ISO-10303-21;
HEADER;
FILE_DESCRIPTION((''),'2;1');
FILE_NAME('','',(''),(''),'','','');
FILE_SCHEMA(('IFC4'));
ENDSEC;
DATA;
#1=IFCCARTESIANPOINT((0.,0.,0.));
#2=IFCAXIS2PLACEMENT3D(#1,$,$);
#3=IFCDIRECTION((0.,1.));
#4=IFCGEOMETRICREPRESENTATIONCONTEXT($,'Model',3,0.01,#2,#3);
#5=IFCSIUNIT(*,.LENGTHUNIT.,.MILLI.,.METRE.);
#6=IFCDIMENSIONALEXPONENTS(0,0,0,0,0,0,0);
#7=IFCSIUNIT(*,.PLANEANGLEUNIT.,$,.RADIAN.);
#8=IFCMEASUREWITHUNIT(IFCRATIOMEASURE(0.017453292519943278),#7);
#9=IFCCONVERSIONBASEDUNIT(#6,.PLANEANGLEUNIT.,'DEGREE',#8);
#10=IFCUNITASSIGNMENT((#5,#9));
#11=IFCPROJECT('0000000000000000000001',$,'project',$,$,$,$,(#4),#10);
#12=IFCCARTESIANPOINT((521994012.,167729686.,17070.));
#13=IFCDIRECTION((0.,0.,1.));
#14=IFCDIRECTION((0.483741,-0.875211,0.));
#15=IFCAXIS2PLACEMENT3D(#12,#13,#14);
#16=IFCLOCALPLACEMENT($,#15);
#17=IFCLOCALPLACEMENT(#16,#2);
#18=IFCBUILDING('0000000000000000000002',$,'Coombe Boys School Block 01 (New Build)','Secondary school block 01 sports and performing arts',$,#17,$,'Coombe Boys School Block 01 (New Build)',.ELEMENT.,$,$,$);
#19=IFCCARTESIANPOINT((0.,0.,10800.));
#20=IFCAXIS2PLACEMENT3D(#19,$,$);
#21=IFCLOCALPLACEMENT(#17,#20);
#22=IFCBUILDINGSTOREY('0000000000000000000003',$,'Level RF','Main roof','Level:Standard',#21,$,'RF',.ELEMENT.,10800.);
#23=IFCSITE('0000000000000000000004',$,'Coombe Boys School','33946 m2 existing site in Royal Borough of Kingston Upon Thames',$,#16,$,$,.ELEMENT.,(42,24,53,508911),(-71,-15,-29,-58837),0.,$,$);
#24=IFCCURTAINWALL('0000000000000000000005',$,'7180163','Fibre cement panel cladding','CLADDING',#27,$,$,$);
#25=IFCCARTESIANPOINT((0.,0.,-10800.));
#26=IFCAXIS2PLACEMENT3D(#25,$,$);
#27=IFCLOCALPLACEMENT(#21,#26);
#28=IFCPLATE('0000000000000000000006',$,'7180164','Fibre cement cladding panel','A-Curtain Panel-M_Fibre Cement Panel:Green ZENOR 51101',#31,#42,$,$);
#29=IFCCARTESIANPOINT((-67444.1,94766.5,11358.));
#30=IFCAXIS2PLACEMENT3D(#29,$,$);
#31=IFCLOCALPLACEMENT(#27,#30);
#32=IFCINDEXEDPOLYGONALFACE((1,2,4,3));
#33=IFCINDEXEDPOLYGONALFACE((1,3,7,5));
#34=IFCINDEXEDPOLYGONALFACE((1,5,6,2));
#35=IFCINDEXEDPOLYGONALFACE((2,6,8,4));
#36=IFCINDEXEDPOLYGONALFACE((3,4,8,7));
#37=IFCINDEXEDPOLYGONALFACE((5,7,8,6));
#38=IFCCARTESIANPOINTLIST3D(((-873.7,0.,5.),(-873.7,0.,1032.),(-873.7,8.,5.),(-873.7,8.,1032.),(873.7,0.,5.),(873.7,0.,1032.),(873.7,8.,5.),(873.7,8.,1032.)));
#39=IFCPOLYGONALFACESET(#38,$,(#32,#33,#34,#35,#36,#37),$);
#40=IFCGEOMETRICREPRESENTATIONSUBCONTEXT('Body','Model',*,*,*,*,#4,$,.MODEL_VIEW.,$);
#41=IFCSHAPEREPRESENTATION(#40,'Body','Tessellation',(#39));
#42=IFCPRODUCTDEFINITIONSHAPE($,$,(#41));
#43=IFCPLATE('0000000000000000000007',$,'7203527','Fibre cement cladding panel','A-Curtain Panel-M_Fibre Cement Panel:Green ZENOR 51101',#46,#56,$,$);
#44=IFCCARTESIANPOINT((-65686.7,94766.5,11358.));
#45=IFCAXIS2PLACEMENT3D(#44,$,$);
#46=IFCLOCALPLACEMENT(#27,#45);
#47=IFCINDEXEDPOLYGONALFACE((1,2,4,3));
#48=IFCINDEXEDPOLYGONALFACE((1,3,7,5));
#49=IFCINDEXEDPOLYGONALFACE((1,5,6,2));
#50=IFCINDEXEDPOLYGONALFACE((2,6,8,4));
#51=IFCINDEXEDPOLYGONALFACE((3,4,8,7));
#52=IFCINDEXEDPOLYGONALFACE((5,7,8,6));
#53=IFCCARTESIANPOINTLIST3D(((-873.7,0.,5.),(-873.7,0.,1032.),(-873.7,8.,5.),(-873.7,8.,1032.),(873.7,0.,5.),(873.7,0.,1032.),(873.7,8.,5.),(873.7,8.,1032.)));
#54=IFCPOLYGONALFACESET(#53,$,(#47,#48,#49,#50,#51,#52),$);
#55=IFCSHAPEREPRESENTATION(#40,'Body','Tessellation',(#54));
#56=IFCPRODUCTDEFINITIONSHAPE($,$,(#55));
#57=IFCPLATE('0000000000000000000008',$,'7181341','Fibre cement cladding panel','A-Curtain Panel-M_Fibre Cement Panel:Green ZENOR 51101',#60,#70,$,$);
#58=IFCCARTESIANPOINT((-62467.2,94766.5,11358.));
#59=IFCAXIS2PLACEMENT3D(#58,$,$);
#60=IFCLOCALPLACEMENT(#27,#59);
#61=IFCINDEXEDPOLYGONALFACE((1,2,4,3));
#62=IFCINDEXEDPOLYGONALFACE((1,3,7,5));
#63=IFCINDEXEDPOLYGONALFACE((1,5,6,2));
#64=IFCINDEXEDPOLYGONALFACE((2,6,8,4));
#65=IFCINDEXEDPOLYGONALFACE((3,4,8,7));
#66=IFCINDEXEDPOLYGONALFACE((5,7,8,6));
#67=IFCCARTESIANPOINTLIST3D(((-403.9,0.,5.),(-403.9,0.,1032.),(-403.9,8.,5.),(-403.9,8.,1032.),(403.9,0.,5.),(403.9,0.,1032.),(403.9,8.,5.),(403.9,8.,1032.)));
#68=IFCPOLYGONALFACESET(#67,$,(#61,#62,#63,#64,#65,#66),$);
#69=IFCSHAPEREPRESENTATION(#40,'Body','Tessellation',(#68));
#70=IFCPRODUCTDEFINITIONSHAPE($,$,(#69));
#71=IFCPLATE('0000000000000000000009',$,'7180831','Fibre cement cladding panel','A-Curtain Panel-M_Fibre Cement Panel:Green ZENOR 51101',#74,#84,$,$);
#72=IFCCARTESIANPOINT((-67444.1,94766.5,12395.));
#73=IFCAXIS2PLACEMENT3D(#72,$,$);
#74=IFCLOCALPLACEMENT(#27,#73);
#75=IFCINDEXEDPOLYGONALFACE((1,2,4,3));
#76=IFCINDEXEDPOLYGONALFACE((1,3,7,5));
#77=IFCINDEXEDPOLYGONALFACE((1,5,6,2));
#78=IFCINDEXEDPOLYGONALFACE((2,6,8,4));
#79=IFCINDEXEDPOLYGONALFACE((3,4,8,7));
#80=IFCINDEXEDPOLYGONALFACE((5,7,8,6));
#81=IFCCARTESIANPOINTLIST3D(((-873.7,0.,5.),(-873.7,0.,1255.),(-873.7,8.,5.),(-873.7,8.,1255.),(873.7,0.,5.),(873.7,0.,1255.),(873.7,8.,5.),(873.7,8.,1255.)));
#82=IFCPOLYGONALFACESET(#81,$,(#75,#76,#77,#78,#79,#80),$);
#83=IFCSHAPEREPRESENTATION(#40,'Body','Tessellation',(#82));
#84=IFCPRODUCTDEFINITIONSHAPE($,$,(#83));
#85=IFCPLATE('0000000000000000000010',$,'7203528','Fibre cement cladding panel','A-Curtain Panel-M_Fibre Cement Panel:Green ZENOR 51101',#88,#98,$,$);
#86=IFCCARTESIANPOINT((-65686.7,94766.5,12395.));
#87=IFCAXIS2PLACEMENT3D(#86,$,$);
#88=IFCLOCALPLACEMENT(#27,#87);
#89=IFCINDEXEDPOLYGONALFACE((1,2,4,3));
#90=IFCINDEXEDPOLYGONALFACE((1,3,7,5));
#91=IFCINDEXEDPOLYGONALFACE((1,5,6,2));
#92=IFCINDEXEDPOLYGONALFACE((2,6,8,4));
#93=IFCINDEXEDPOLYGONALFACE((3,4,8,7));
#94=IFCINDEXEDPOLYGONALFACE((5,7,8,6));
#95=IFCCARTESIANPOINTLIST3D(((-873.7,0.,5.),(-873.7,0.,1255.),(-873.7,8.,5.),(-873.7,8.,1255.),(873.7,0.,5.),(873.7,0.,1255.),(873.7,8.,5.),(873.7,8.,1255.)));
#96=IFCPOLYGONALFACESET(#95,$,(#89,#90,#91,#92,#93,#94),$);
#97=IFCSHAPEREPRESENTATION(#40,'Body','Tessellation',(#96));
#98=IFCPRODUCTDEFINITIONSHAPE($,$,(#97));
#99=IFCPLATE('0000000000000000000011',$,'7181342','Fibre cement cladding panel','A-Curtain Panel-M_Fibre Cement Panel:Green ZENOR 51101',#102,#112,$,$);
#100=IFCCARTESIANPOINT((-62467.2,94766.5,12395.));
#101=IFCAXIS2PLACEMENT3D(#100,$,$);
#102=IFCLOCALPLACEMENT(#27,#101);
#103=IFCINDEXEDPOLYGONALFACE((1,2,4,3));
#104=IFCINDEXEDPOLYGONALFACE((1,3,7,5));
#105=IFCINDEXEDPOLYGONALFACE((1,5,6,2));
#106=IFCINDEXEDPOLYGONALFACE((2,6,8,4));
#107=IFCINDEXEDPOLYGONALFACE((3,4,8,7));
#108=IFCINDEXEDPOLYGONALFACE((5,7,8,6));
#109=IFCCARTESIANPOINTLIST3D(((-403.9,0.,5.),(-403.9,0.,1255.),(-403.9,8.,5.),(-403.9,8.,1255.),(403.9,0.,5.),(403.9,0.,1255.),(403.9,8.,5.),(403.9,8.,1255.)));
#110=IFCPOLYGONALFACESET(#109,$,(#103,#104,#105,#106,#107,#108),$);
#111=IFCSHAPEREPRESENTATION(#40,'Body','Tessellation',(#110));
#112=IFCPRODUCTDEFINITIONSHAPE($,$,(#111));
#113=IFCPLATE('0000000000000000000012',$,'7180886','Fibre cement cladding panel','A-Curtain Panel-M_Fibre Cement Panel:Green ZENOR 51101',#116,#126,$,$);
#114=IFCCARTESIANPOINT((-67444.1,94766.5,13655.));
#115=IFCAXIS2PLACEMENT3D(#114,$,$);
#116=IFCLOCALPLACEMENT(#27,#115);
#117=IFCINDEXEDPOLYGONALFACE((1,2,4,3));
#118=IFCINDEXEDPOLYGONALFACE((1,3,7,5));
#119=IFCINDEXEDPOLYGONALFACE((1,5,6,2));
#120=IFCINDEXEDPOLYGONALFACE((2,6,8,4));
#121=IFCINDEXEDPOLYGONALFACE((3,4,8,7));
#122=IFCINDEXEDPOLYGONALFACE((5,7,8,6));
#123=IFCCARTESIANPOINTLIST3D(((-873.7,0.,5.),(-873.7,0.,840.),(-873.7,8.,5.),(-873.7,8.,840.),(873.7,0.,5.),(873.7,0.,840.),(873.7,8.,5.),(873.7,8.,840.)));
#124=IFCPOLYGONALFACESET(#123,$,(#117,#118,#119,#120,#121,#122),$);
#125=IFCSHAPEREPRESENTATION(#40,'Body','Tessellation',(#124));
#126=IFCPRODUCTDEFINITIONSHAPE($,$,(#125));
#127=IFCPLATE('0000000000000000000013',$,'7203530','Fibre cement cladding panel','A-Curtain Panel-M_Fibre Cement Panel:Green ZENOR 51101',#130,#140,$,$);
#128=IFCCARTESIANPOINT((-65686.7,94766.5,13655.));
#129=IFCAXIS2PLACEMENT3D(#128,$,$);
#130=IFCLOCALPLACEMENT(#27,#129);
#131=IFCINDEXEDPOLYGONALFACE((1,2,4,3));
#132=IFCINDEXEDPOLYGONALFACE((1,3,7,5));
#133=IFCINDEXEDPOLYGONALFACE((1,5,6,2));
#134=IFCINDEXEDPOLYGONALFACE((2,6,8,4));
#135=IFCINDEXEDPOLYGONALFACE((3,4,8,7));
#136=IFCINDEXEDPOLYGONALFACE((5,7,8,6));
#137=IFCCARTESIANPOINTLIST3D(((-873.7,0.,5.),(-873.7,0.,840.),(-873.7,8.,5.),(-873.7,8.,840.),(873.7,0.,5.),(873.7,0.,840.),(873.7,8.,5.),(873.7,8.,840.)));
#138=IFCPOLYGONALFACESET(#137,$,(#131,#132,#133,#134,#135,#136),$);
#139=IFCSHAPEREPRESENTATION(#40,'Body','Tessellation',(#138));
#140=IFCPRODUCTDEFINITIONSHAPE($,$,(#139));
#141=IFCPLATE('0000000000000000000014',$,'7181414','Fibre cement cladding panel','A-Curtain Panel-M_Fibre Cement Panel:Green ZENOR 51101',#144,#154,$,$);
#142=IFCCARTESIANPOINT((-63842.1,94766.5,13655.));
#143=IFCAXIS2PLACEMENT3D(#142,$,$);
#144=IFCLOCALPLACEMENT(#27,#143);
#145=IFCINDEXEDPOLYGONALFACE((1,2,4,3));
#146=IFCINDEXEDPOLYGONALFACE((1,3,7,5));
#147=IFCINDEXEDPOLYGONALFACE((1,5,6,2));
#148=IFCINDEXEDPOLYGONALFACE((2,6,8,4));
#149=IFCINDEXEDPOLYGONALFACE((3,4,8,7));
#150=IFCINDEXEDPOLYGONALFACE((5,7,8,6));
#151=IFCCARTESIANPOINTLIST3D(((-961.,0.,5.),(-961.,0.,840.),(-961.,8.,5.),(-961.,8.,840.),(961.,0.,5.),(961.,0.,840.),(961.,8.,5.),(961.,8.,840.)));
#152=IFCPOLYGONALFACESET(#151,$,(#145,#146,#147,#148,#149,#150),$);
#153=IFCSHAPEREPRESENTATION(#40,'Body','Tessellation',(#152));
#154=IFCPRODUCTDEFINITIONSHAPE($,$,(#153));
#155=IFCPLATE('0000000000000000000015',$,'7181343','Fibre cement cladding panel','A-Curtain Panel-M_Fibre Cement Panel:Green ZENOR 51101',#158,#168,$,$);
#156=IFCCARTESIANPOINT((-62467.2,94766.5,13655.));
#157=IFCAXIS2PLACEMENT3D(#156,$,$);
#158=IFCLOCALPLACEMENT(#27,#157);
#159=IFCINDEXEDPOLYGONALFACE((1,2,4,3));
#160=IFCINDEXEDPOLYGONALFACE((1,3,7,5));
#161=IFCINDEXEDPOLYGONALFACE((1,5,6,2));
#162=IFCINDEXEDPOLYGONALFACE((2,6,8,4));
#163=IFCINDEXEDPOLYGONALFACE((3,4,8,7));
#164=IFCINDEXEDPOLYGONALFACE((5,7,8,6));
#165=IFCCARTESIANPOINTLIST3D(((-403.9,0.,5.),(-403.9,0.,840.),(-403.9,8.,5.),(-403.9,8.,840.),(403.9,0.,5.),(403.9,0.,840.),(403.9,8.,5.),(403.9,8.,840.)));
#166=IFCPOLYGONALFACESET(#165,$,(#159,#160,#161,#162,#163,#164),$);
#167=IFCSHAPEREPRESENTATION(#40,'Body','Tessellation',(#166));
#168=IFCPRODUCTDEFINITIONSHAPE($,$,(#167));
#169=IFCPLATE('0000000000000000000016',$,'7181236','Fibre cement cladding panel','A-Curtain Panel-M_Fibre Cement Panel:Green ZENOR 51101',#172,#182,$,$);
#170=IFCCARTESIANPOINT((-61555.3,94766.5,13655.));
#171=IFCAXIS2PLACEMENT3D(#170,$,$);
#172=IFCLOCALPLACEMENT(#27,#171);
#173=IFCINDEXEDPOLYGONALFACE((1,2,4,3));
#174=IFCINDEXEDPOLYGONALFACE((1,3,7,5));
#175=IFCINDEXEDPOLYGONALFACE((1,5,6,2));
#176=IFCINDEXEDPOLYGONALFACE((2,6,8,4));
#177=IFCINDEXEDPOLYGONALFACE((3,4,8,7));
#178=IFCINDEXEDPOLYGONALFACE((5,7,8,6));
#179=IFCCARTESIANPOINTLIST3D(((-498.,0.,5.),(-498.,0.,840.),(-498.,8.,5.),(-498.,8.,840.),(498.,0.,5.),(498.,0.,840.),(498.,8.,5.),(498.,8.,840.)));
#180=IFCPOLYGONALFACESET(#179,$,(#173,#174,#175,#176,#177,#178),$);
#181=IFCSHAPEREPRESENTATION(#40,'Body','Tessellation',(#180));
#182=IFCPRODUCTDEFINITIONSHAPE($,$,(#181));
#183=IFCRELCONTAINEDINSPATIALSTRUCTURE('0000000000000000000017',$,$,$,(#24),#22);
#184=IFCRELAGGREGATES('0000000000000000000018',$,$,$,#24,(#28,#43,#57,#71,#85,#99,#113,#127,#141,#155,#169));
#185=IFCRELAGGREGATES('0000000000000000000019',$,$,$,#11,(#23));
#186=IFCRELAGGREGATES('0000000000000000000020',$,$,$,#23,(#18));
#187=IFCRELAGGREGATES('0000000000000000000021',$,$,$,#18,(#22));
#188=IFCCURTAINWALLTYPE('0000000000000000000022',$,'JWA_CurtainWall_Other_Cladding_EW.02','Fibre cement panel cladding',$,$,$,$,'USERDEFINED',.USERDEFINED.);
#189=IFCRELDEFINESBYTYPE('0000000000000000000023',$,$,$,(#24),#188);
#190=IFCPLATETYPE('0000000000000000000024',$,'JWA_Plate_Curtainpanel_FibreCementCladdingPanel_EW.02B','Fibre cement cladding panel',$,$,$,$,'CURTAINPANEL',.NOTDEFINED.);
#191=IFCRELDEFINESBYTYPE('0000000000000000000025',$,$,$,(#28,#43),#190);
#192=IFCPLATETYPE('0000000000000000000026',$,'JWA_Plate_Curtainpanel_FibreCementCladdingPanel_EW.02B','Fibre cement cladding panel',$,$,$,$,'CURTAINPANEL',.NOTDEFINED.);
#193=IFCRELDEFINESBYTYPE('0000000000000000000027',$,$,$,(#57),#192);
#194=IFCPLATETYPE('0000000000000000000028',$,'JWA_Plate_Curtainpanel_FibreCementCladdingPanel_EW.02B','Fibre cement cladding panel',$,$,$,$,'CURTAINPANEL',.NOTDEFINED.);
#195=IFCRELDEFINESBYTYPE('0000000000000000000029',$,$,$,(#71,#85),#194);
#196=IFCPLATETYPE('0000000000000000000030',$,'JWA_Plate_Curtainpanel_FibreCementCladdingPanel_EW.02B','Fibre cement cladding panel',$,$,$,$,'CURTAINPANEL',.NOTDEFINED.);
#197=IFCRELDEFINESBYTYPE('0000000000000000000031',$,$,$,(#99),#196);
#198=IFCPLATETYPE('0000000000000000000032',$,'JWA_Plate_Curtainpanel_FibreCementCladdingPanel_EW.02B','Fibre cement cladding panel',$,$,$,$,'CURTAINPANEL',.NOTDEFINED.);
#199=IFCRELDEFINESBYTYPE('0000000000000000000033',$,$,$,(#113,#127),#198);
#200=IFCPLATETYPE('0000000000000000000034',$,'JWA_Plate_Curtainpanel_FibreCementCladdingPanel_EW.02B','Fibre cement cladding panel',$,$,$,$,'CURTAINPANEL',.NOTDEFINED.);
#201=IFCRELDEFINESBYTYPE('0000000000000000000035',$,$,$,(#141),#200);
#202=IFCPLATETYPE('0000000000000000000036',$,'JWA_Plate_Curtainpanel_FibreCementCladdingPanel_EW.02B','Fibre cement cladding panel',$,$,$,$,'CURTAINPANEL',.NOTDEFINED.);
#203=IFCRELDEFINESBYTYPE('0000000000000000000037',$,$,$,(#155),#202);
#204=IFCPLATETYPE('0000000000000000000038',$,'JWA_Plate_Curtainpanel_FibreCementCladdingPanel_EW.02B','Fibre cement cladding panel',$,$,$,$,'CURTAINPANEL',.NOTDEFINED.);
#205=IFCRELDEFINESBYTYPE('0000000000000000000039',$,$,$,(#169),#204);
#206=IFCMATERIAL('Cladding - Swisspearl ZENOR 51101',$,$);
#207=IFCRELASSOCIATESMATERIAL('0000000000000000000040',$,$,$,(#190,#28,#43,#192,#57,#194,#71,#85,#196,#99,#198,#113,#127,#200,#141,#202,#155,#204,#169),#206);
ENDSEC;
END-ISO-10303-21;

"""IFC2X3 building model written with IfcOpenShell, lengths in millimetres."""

from ifc_helpers import new_model, entity, si_unit, converted_unit, direction, frame, origin, origin_2d_with_axis, place, context, subcontext, project, spatial, rectangle, extrude, source, transform, mapped, material, type_object, type_shapes, element, aggregate, save


model = new_model("IFC2X3")

# Units and contexts
model_context = context("Model", 3, precision=0.01, world=origin(), true_north=direction((0.0, 1.0)))
body_context = subcontext(model_context, "Body", "Model", "MODEL_VIEW")
ifc_project = project(units=[si_unit("LENGTHUNIT", "METRE", prefix="MILLI"), converted_unit("PLANEANGLEUNIT", "DEGREE", entity("IfcRatioMeasure", 0.017453292519943278), si_unit("PLANEANGLEUNIT", "RADIAN"), dimensions=[0, 0, 0, 0, 0, 0, 0])], contexts=[model_context])

# Site, building, storey
site_placement = place(None, frame((521994012.0, 167729686.0, 17070.0), z_axis=(0.0, 0.0, 1.0), x_axis=(0.483741, -0.875211, 0.0)))
site = spatial("IfcSite", under=ifc_project, at=site_placement, Name="Coombe Boys School", Description="33946 m2 existing site in Royal Borough of Kingston Upon Thames", CompositionType="ELEMENT", RefLatitude=(42, 24, 53, 508911), RefLongitude=(-71, -15, -29, -58837), RefElevation=0.0)
building_placement = place(site_placement, origin())
building = spatial("IfcBuilding", under=site, at=building_placement, Name="Coombe Boys School Block 01 (New Build)", Description="Secondary school block 01 sports and performing arts", LongName="Coombe Boys School Block 01 (New Build)", CompositionType="ELEMENT")
storey_placement = place(building_placement, frame((0.0, 0.0, 10800.0)))
storey = spatial("IfcBuildingStorey", under=building, at=storey_placement, Name="Level RF", Description="Main roof", ObjectType="Level:Standard", LongName="RF", CompositionType="ELEMENT", Elevation=10800.0)

# Curtain wall, plates
curtain_wall_type = type_object("IfcCurtainWallType", Name="JWA_CurtainWall_Other_Cladding_EW.02", Description="Fibre cement panel cladding", ElementType="USERDEFINED", PredefinedType="USERDEFINED")
curtain_wall_placement = place(storey_placement, frame((0.0, 0.0, -10800.0)))
curtain_wall = element("IfcCurtainWall", 1, at=curtain_wall_placement, inside=storey, type_object=curtain_wall_type, Name="7180163", Description="Fibre cement panel cladding", ObjectType="CLADDING")
ifc_material_1 = material(Name="Cladding - Swisspearl ZENOR 51101")
plate_type_1 = type_object("IfcPlateType", Name="JWA_Plate_Curtainpanel_FibreCementCladdingPanel_EW.02B", Description="Fibre cement cladding panel", ElementType="CURTAINPANEL", PredefinedType="NOTDEFINED", material=ifc_material_1)
shared_shape_1 = source(origin(), body_context, "Body", "SweptSolid", [
    extrude(rectangle(XDim=8.0, YDim=1747.3, at=origin_2d_with_axis()), frame((0.0, 4.0, 5.0), z_axis=(0.0, 0.0, 1.0), x_axis=(0.0, 1.0, 0.0)), (0.0, 0.0, 1.0), 1027.0),
])
type_shapes(plate_type_1, [shared_shape_1])
plate_1_placement = place(curtain_wall_placement, frame((-67444.1, 94766.5, 11358.0)))
plate_1 = element("IfcPlate", 2, at=plate_1_placement, type_object=plate_type_1, material=ifc_material_1, Name="7180164", Description="Fibre cement cladding panel", ObjectType="A-Curtain Panel-M_Fibre Cement Panel:Green ZENOR 51101", context=body_context, shape_type="MappedRepresentation", body=[
    mapped(shared_shape_1, transform((0.0, 0.0, 0.0), scale=1.0)),
])
plate_2_placement = place(curtain_wall_placement, frame((-65686.7, 94766.5, 11358.0)))
plate_2 = element("IfcPlate", 3, at=plate_2_placement, type_object=plate_type_1, material=ifc_material_1, Name="7203527", Description="Fibre cement cladding panel", ObjectType="A-Curtain Panel-M_Fibre Cement Panel:Green ZENOR 51101", context=body_context, shape_type="MappedRepresentation", body=[
    mapped(shared_shape_1, transform((0.0, 0.0, 0.0), scale=1.0)),
])
plate_type_2 = type_object("IfcPlateType", Name="JWA_Plate_Curtainpanel_FibreCementCladdingPanel_EW.02B", Description="Fibre cement cladding panel", ElementType="CURTAINPANEL", PredefinedType="NOTDEFINED", material=ifc_material_1)
shared_shape_2 = source(origin(), body_context, "Body", "SweptSolid", [
    extrude(rectangle(XDim=8.0, YDim=807.8, at=origin_2d_with_axis()), frame((0.0, 4.0, 5.0), z_axis=(0.0, 0.0, 1.0), x_axis=(0.0, 1.0, 0.0)), (0.0, 0.0, 1.0), 1027.0),
])
type_shapes(plate_type_2, [shared_shape_2])
plate_3_placement = place(curtain_wall_placement, frame((-62467.2, 94766.5, 11358.0)))
plate_3 = element("IfcPlate", 4, at=plate_3_placement, type_object=plate_type_2, material=ifc_material_1, Name="7181341", Description="Fibre cement cladding panel", ObjectType="A-Curtain Panel-M_Fibre Cement Panel:Green ZENOR 51101", context=body_context, shape_type="MappedRepresentation", body=[
    mapped(shared_shape_2, transform((0.0, 0.0, 0.0), scale=1.0)),
])
plate_type_3 = type_object("IfcPlateType", Name="JWA_Plate_Curtainpanel_FibreCementCladdingPanel_EW.02B", Description="Fibre cement cladding panel", ElementType="CURTAINPANEL", PredefinedType="NOTDEFINED", material=ifc_material_1)
shared_shape_3 = source(origin(), body_context, "Body", "SweptSolid", [
    extrude(rectangle(XDim=8.0, YDim=1747.3, at=origin_2d_with_axis()), frame((0.0, 4.0, 5.0), z_axis=(0.0, 0.0, 1.0), x_axis=(0.0, 1.0, 0.0)), (0.0, 0.0, 1.0), 1250.0),
])
type_shapes(plate_type_3, [shared_shape_3])
plate_4_placement = place(curtain_wall_placement, frame((-67444.1, 94766.5, 12395.0)))
plate_4 = element("IfcPlate", 5, at=plate_4_placement, type_object=plate_type_3, material=ifc_material_1, Name="7180831", Description="Fibre cement cladding panel", ObjectType="A-Curtain Panel-M_Fibre Cement Panel:Green ZENOR 51101", context=body_context, shape_type="MappedRepresentation", body=[
    mapped(shared_shape_3, transform((0.0, 0.0, 0.0), scale=1.0)),
])
plate_5_placement = place(curtain_wall_placement, frame((-65686.7, 94766.5, 12395.0)))
plate_5 = element("IfcPlate", 6, at=plate_5_placement, type_object=plate_type_3, material=ifc_material_1, Name="7203528", Description="Fibre cement cladding panel", ObjectType="A-Curtain Panel-M_Fibre Cement Panel:Green ZENOR 51101", context=body_context, shape_type="MappedRepresentation", body=[
    mapped(shared_shape_3, transform((0.0, 0.0, 0.0), scale=1.0)),
])
plate_type_4 = type_object("IfcPlateType", Name="JWA_Plate_Curtainpanel_FibreCementCladdingPanel_EW.02B", Description="Fibre cement cladding panel", ElementType="CURTAINPANEL", PredefinedType="NOTDEFINED", material=ifc_material_1)
shared_shape_4 = source(origin(), body_context, "Body", "SweptSolid", [
    extrude(rectangle(XDim=8.0, YDim=807.8, at=origin_2d_with_axis()), frame((0.0, 4.0, 5.0), z_axis=(0.0, 0.0, 1.0), x_axis=(0.0, 1.0, 0.0)), (0.0, 0.0, 1.0), 1250.0),
])
type_shapes(plate_type_4, [shared_shape_4])
plate_6_placement = place(curtain_wall_placement, frame((-62467.2, 94766.5, 12395.0)))
plate_6 = element("IfcPlate", 7, at=plate_6_placement, type_object=plate_type_4, material=ifc_material_1, Name="7181342", Description="Fibre cement cladding panel", ObjectType="A-Curtain Panel-M_Fibre Cement Panel:Green ZENOR 51101", context=body_context, shape_type="MappedRepresentation", body=[
    mapped(shared_shape_4, transform((0.0, 0.0, 0.0), scale=1.0)),
])
plate_type_5 = type_object("IfcPlateType", Name="JWA_Plate_Curtainpanel_FibreCementCladdingPanel_EW.02B", Description="Fibre cement cladding panel", ElementType="CURTAINPANEL", PredefinedType="NOTDEFINED", material=ifc_material_1)
shared_shape_5 = source(origin(), body_context, "Body", "SweptSolid", [
    extrude(rectangle(XDim=8.0, YDim=1747.3, at=origin_2d_with_axis()), frame((0.0, 4.0, 5.0), z_axis=(0.0, 0.0, 1.0), x_axis=(0.0, 1.0, 0.0)), (0.0, 0.0, 1.0), 835.0),
])
type_shapes(plate_type_5, [shared_shape_5])
plate_7_placement = place(curtain_wall_placement, frame((-67444.1, 94766.5, 13655.0)))
plate_7 = element("IfcPlate", 8, at=plate_7_placement, type_object=plate_type_5, material=ifc_material_1, Name="7180886", Description="Fibre cement cladding panel", ObjectType="A-Curtain Panel-M_Fibre Cement Panel:Green ZENOR 51101", context=body_context, shape_type="MappedRepresentation", body=[
    mapped(shared_shape_5, transform((0.0, 0.0, 0.0), scale=1.0)),
])
plate_8_placement = place(curtain_wall_placement, frame((-65686.7, 94766.5, 13655.0)))
plate_8 = element("IfcPlate", 9, at=plate_8_placement, type_object=plate_type_5, material=ifc_material_1, Name="7203530", Description="Fibre cement cladding panel", ObjectType="A-Curtain Panel-M_Fibre Cement Panel:Green ZENOR 51101", context=body_context, shape_type="MappedRepresentation", body=[
    mapped(shared_shape_5, transform((0.0, 0.0, 0.0), scale=1.0)),
])
plate_type_6 = type_object("IfcPlateType", Name="JWA_Plate_Curtainpanel_FibreCementCladdingPanel_EW.02B", Description="Fibre cement cladding panel", ElementType="CURTAINPANEL", PredefinedType="NOTDEFINED", material=ifc_material_1)
shared_shape_6 = source(origin(), body_context, "Body", "SweptSolid", [
    extrude(rectangle(XDim=8.0, YDim=1922.0, at=origin_2d_with_axis()), frame((0.0, 4.0, 5.0), z_axis=(0.0, 0.0, 1.0), x_axis=(0.0, 1.0, 0.0)), (0.0, 0.0, 1.0), 835.0),
])
type_shapes(plate_type_6, [shared_shape_6])
plate_9_placement = place(curtain_wall_placement, frame((-63842.1, 94766.5, 13655.0)))
plate_9 = element("IfcPlate", 10, at=plate_9_placement, type_object=plate_type_6, material=ifc_material_1, Name="7181414", Description="Fibre cement cladding panel", ObjectType="A-Curtain Panel-M_Fibre Cement Panel:Green ZENOR 51101", context=body_context, shape_type="MappedRepresentation", body=[
    mapped(shared_shape_6, transform((0.0, 0.0, 0.0), scale=1.0)),
])
plate_type_7 = type_object("IfcPlateType", Name="JWA_Plate_Curtainpanel_FibreCementCladdingPanel_EW.02B", Description="Fibre cement cladding panel", ElementType="CURTAINPANEL", PredefinedType="NOTDEFINED", material=ifc_material_1)
shared_shape_7 = source(origin(), body_context, "Body", "SweptSolid", [
    extrude(rectangle(XDim=8.0, YDim=807.8, at=origin_2d_with_axis()), frame((0.0, 4.0, 5.0), z_axis=(0.0, 0.0, 1.0), x_axis=(0.0, 1.0, 0.0)), (0.0, 0.0, 1.0), 835.0),
])
type_shapes(plate_type_7, [shared_shape_7])
plate_10_placement = place(curtain_wall_placement, frame((-62467.2, 94766.5, 13655.0)))
plate_10 = element("IfcPlate", 11, at=plate_10_placement, type_object=plate_type_7, material=ifc_material_1, Name="7181343", Description="Fibre cement cladding panel", ObjectType="A-Curtain Panel-M_Fibre Cement Panel:Green ZENOR 51101", context=body_context, shape_type="MappedRepresentation", body=[
    mapped(shared_shape_7, transform((0.0, 0.0, 0.0), scale=1.0)),
])
plate_type_8 = type_object("IfcPlateType", Name="JWA_Plate_Curtainpanel_FibreCementCladdingPanel_EW.02B", Description="Fibre cement cladding panel", ElementType="CURTAINPANEL", PredefinedType="NOTDEFINED", material=ifc_material_1)
shared_shape_8 = source(origin(), body_context, "Body", "SweptSolid", [
    extrude(rectangle(XDim=8.0, YDim=996.0, at=origin_2d_with_axis()), frame((0.0, 4.0, 5.0), z_axis=(0.0, 0.0, 1.0), x_axis=(0.0, 1.0, 0.0)), (0.0, 0.0, 1.0), 835.0),
])
type_shapes(plate_type_8, [shared_shape_8])
plate_11_placement = place(curtain_wall_placement, frame((-61555.3, 94766.5, 13655.0)))
plate_11 = element("IfcPlate", 12, at=plate_11_placement, type_object=plate_type_8, material=ifc_material_1, Name="7181236", Description="Fibre cement cladding panel", ObjectType="A-Curtain Panel-M_Fibre Cement Panel:Green ZENOR 51101", context=body_context, shape_type="MappedRepresentation", body=[
    mapped(shared_shape_8, transform((0.0, 0.0, 0.0), scale=1.0)),
])
aggregate(curtain_wall, [plate_1, plate_2, plate_3, plate_4, plate_5, plate_6, plate_7, plate_8, plate_9, plate_10, plate_11])

save(model, "model.ifc")
